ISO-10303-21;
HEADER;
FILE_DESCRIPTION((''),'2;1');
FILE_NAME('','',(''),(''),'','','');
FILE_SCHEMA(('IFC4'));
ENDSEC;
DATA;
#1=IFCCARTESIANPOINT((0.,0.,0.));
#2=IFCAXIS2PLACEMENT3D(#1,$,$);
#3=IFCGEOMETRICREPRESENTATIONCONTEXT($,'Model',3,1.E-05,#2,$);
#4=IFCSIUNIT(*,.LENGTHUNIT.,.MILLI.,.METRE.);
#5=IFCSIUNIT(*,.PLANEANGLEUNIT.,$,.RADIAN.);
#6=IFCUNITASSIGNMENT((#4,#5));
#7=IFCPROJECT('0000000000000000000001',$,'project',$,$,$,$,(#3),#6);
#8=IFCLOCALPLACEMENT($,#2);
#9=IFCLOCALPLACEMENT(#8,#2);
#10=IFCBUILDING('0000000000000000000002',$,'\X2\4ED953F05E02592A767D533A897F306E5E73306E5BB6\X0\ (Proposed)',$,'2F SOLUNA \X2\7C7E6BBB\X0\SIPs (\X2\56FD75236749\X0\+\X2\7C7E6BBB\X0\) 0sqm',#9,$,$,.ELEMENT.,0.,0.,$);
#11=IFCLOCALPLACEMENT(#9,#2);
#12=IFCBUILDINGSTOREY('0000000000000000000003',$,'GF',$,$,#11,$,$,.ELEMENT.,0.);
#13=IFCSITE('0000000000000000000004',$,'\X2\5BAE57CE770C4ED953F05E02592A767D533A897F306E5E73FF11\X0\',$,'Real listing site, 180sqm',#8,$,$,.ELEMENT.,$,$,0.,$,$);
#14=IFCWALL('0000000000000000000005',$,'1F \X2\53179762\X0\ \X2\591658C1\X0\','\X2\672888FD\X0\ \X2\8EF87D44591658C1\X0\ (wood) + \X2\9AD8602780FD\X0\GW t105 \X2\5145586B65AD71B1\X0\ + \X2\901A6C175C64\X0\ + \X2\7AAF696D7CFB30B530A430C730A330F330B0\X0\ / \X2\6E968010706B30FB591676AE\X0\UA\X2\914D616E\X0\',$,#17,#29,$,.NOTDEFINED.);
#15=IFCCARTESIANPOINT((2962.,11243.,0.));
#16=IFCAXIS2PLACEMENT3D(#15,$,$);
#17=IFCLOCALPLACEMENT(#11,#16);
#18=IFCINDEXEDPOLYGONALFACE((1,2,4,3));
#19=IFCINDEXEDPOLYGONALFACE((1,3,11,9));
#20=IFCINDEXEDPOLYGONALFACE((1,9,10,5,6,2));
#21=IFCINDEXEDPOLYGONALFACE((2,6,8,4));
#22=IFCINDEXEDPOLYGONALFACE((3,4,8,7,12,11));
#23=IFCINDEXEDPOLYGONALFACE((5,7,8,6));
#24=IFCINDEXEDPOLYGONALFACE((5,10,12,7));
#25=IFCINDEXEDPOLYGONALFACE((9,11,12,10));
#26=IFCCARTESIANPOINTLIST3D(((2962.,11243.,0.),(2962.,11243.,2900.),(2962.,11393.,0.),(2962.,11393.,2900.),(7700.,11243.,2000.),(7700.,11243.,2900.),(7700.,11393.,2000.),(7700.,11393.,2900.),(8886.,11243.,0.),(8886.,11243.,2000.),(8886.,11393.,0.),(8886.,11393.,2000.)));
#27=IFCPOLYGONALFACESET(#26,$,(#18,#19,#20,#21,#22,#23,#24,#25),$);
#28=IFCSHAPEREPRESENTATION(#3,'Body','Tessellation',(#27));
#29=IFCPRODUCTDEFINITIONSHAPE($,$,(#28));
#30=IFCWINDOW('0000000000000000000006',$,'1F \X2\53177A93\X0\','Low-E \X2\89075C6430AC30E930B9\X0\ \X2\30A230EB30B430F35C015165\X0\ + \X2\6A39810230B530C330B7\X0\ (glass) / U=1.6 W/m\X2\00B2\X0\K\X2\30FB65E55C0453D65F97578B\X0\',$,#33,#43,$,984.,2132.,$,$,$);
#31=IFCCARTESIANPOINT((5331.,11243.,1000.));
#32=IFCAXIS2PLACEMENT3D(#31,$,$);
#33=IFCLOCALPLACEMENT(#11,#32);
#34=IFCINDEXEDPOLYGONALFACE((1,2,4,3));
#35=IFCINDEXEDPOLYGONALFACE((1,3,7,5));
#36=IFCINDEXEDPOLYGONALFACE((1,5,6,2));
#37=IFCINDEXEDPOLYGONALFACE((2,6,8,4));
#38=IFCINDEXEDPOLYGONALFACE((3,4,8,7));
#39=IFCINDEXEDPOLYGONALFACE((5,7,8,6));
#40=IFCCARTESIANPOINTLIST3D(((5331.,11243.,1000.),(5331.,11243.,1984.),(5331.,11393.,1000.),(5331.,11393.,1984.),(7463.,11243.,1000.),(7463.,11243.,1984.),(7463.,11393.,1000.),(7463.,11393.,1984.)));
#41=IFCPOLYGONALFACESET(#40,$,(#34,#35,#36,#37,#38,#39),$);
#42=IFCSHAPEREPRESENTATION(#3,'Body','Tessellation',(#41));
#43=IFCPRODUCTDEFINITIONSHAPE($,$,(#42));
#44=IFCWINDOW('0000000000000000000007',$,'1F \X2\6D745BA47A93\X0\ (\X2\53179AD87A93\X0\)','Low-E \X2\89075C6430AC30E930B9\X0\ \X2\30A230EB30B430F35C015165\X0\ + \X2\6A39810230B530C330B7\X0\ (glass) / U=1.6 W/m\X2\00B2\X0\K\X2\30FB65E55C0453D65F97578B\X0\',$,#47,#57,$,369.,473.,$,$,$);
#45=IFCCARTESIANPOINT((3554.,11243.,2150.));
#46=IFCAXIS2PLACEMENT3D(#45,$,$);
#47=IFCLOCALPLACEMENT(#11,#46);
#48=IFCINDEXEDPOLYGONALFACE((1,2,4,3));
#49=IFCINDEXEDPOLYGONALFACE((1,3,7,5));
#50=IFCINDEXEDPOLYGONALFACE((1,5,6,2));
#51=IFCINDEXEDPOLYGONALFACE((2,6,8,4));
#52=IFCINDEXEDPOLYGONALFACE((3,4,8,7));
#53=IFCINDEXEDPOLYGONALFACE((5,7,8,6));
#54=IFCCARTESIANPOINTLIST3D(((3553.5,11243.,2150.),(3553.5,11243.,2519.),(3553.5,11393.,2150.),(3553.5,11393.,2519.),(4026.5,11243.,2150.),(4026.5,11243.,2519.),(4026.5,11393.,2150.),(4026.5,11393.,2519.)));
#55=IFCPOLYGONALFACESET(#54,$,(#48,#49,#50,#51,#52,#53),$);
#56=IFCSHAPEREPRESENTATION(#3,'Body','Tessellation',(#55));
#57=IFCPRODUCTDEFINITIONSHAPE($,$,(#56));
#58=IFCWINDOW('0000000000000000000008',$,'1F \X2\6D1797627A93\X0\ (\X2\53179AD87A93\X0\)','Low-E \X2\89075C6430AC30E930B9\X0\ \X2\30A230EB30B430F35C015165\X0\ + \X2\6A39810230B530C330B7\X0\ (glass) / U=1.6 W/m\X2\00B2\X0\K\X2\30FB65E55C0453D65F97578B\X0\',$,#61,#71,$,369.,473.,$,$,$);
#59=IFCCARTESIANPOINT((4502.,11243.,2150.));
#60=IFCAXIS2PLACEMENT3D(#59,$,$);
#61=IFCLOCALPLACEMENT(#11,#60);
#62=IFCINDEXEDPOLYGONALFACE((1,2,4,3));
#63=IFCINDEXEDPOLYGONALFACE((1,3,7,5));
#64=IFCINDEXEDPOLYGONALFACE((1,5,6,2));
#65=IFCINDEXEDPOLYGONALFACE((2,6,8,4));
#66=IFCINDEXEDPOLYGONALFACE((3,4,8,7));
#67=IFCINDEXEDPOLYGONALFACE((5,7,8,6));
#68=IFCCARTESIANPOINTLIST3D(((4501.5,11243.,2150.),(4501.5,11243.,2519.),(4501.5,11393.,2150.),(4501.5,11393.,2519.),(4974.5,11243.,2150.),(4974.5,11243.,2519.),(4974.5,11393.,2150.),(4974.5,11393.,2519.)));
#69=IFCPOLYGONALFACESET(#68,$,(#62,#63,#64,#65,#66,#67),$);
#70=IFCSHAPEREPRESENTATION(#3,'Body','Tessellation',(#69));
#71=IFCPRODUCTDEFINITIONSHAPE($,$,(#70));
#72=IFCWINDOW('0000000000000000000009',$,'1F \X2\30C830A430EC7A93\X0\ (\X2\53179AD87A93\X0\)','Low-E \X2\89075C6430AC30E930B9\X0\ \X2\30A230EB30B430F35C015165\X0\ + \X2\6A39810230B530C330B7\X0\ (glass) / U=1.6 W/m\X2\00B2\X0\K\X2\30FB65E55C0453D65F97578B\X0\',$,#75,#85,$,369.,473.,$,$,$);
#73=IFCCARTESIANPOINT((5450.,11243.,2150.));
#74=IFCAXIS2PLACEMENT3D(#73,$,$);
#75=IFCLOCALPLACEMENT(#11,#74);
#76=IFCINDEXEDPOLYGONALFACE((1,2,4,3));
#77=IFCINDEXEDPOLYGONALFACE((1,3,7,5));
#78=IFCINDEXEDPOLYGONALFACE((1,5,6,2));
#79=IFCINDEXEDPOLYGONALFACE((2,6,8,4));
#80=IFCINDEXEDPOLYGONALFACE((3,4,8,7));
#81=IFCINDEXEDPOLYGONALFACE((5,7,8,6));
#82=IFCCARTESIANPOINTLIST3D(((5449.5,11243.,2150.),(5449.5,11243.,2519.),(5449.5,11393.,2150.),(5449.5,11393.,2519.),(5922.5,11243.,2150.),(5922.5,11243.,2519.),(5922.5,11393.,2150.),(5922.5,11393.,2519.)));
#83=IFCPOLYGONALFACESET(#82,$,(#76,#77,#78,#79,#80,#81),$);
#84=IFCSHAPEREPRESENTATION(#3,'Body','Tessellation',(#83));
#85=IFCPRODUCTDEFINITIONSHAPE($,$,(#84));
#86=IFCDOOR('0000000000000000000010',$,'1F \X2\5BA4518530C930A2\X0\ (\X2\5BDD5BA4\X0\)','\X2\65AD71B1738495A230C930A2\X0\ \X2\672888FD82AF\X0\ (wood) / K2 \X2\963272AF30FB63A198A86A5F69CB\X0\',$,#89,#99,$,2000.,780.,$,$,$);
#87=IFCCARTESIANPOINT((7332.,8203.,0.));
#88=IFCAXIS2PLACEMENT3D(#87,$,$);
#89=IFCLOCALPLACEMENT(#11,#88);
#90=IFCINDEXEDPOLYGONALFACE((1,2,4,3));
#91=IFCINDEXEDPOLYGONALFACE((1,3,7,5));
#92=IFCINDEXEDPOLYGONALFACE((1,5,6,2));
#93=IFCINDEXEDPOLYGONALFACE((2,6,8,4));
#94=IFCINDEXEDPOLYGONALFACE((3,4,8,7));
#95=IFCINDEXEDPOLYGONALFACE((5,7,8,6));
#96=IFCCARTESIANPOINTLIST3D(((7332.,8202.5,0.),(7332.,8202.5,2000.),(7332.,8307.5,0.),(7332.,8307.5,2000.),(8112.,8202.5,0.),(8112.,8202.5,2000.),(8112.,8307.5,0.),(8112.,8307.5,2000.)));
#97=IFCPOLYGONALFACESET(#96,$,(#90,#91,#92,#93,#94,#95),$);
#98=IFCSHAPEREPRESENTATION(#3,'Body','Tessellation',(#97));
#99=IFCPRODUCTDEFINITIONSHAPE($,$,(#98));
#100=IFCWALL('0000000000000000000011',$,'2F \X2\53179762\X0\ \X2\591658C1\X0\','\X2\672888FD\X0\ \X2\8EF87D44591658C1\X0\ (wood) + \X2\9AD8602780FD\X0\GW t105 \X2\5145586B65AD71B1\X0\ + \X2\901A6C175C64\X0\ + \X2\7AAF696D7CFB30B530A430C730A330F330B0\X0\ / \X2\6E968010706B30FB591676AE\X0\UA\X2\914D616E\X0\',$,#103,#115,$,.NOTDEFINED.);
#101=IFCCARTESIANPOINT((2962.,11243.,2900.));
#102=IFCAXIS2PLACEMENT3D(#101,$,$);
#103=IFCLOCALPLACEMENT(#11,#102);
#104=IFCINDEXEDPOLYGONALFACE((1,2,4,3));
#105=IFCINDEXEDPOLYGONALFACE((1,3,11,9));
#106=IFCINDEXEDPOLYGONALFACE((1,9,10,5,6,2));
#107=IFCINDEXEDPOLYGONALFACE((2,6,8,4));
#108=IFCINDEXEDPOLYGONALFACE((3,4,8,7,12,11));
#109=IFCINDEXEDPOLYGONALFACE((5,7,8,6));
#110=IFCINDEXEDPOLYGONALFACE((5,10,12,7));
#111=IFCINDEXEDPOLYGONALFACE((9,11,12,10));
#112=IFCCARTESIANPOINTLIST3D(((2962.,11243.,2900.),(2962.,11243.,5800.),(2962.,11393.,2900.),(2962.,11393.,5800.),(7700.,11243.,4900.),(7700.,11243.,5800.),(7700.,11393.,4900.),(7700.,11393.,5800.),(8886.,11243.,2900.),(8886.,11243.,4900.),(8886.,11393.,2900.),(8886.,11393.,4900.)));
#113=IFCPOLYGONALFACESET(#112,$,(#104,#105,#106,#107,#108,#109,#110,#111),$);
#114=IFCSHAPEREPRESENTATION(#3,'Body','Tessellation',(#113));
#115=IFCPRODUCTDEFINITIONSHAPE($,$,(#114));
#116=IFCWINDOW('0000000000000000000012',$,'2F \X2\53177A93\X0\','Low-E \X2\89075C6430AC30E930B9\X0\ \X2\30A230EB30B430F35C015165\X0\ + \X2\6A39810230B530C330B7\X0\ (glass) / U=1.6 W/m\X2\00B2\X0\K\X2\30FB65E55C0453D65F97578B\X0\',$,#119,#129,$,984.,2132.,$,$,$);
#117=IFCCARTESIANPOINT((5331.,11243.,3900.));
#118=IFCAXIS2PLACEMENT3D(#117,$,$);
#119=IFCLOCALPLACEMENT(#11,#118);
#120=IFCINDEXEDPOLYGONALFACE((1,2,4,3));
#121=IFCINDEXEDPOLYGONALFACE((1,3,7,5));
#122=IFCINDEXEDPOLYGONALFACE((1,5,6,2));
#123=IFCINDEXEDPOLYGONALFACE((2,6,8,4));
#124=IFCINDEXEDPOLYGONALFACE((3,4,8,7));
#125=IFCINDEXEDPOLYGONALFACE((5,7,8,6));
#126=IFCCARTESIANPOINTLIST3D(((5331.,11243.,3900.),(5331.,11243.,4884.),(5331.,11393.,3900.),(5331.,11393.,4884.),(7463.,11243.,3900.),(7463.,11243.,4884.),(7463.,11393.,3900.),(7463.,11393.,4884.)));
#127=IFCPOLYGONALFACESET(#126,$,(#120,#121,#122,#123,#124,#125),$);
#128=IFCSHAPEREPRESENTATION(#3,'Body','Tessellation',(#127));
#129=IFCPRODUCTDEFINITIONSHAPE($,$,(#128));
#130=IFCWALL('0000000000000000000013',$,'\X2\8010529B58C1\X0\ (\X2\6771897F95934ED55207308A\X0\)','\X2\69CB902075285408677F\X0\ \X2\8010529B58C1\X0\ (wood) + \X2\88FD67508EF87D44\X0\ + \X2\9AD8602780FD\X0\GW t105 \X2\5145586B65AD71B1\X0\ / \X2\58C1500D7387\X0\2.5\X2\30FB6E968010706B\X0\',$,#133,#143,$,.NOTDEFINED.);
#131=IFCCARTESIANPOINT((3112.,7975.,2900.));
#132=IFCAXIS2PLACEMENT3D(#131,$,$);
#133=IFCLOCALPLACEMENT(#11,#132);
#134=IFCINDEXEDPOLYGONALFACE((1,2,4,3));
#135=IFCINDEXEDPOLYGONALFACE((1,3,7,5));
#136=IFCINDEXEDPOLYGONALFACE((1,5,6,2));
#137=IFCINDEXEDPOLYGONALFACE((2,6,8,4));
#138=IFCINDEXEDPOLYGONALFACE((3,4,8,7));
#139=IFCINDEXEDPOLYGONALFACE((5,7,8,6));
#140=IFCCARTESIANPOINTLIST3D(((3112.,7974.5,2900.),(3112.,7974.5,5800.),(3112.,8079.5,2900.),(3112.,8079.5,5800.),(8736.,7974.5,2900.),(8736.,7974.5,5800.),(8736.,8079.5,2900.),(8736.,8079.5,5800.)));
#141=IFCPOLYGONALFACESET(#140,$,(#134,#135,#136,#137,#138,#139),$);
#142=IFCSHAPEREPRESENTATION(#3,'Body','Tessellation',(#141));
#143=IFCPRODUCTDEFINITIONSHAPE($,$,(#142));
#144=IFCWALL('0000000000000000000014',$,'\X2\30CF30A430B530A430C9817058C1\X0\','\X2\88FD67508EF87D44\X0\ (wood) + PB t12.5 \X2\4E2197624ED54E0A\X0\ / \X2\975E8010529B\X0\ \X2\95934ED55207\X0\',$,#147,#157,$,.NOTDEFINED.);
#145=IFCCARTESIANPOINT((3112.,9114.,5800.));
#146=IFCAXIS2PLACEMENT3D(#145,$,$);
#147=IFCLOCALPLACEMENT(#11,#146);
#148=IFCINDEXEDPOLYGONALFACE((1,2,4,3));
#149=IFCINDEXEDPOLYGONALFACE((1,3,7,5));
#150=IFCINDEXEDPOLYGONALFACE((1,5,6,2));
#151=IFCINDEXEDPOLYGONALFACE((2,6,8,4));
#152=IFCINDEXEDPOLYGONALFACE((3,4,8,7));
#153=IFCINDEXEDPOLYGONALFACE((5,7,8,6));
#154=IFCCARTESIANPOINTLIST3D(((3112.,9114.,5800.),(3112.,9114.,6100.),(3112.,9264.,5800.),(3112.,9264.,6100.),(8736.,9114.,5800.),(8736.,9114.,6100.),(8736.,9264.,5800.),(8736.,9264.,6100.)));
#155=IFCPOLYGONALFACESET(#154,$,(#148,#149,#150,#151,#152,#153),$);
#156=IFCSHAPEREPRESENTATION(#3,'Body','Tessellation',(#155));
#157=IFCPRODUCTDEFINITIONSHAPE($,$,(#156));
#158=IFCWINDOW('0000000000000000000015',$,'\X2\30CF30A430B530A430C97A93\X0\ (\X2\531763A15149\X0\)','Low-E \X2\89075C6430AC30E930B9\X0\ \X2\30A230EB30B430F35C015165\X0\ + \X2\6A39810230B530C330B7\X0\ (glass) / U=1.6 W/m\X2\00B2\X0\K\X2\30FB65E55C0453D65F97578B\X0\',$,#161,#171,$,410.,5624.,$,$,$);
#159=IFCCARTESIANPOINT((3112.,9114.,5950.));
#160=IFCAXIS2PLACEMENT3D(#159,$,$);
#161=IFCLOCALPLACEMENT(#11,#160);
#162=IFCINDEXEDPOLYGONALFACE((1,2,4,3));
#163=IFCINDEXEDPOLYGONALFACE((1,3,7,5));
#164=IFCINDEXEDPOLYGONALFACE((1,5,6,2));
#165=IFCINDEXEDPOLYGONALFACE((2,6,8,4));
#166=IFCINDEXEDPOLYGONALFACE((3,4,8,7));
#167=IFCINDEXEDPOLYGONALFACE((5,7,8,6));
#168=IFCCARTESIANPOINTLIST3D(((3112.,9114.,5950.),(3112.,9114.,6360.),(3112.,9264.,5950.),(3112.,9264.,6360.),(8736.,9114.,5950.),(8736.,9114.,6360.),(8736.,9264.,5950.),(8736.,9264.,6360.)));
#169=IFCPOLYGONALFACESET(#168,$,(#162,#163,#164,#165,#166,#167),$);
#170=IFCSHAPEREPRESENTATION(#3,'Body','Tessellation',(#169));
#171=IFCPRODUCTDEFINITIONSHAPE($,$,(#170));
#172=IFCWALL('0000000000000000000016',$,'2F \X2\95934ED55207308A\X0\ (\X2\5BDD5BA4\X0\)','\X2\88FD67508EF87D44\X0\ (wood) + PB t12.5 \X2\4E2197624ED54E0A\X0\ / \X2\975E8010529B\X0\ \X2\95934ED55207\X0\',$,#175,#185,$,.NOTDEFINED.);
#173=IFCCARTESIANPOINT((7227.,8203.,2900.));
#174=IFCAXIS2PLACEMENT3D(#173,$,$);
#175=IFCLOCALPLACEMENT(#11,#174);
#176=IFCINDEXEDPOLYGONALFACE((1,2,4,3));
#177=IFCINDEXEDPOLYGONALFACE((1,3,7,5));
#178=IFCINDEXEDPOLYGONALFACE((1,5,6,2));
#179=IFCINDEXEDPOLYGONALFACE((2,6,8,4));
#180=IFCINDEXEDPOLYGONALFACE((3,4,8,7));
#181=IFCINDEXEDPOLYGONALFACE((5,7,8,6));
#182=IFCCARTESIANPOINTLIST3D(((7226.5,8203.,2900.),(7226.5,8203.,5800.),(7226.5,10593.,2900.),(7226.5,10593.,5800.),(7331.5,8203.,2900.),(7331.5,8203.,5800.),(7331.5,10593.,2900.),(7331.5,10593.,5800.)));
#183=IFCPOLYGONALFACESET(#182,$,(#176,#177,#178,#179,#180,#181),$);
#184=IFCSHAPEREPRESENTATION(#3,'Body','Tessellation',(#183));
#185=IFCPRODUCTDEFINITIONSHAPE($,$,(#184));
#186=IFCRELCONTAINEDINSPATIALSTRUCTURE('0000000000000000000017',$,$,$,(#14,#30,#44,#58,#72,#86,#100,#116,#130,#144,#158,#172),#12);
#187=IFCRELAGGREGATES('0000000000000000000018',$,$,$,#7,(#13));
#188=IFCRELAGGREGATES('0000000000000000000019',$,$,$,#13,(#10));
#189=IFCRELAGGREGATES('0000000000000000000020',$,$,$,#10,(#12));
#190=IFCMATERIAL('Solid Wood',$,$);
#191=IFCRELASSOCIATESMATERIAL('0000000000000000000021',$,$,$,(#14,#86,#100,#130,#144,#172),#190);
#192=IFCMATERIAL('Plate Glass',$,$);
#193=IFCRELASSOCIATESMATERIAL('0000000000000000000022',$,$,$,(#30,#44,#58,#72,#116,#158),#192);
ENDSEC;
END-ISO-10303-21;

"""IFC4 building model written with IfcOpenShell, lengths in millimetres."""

from ifc_helpers import new_model, si_unit, frame, frame_2d, origin, place, context, project, spatial, rectangle, extrude, material, element, fill, save


model = new_model("IFC4")

# Units and contexts
model_context = context("Model", 3, precision=1e-05, world=origin())
ifc_project = project(units=[si_unit("LENGTHUNIT", "METRE", prefix="MILLI"), si_unit("PLANEANGLEUNIT", "RADIAN")], contexts=[model_context])

# Site, building, storey
site_placement = place(None, origin())
site = spatial("IfcSite", under=ifc_project, at=site_placement, Name="宮城県仙台市太白区西の平１", ObjectType="Real listing site, 180sqm", CompositionType="ELEMENT", RefElevation=0.0)
building_placement = place(site_placement, origin())
building = spatial("IfcBuilding", under=site, at=building_placement, Name="仙台市太白区西の平の家 (Proposed)", ObjectType="2F SOLUNA 籾殻SIPs (国産杉+籾殻) 0sqm", CompositionType="ELEMENT", ElevationOfRefHeight=0.0, ElevationOfTerrain=0.0)
storey_placement = place(building_placement, origin())
storey = spatial("IfcBuildingStorey", under=building, at=storey_placement, Name="GF", CompositionType="ELEMENT", Elevation=0.0)

# Wall, openings, windows
ifc_material_1 = material(Name="Solid Wood")
wall_1_placement = place(storey_placement, frame((2962.0, 11243.0, 0.0)))
wall_1 = element("IfcWall", 1, at=wall_1_placement, inside=storey, material=ifc_material_1, Name="1F 北面 外壁", Description="木製 軸組外壁 (wood) + 高性能GW t105 充填断熱 + 通気層 + 窯業系サイディング / 準耐火・外皮UA配慮", PredefinedType="NOTDEFINED", context=model_context, shape_type="SweptSolid", body=[
    extrude(rectangle(XDim=5924.0, YDim=150.0, at=frame_2d((2962.0, 75.0))), frame((2962.0, 11243.0, 0.0)), (0.0, 0.0, 1.0), 2900.0),
])
opening_1_placement = place(storey_placement, frame((5331.0, 11243.0, 1000.0)))
opening_1 = element("IfcOpeningElement", 2, at=opening_1_placement, cuts=wall_1, PredefinedType="NOTDEFINED", context=model_context, shape_type="SweptSolid", body=[
    extrude(rectangle(XDim=2132.0, YDim=150.0, at=frame_2d((1066.0, 75.0))), frame((5331.0, 11243.0, 1000.0)), (0.0, 0.0, 1.0), 984.0),
])
opening_2_placement = place(storey_placement, frame((3554.0, 11243.0, 2150.0)))
opening_2 = element("IfcOpeningElement", 3, at=opening_2_placement, cuts=wall_1, PredefinedType="NOTDEFINED", context=model_context, shape_type="SweptSolid", body=[
    extrude(rectangle(XDim=473.0, YDim=150.0, at=frame_2d((236.0, 75.0))), frame((3554.0, 11243.0, 2150.0)), (0.0, 0.0, 1.0), 369.0),
])
opening_3_placement = place(storey_placement, frame((4502.0, 11243.0, 2150.0)))
opening_3 = element("IfcOpeningElement", 4, at=opening_3_placement, cuts=wall_1, PredefinedType="NOTDEFINED", context=model_context, shape_type="SweptSolid", body=[
    extrude(rectangle(XDim=473.0, YDim=150.0, at=frame_2d((236.0, 75.0))), frame((4502.0, 11243.0, 2150.0)), (0.0, 0.0, 1.0), 369.0),
])
opening_4_placement = place(storey_placement, frame((5450.0, 11243.0, 2150.0)))
opening_4 = element("IfcOpeningElement", 5, at=opening_4_placement, cuts=wall_1, PredefinedType="NOTDEFINED", context=model_context, shape_type="SweptSolid", body=[
    extrude(rectangle(XDim=473.0, YDim=150.0, at=frame_2d((236.0, 75.0))), frame((5450.0, 11243.0, 2150.0)), (0.0, 0.0, 1.0), 369.0),
])
ifc_material_2 = material(Name="Plate Glass")
window_1_placement = place(storey_placement, frame((5331.0, 11243.0, 1000.0)))
window_1 = element("IfcWindow", 6, at=window_1_placement, inside=storey, material=ifc_material_2, Name="1F 北窓", Description="Low-E 複層ガラス アルゴン封入 + 樹脂サッシ (glass) / U=1.6 W/m²K・日射取得型", OverallHeight=984.0, OverallWidth=2132.0, context=model_context, shape_type="SweptSolid", body=[
    extrude(rectangle(XDim=2132.0, YDim=150.0, at=frame_2d((1066.0, 75.0))), frame((5331.0, 11243.0, 1000.0)), (0.0, 0.0, 1.0), 984.0),
])
fill(opening_1, window_1)
window_2_placement = place(storey_placement, frame((3554.0, 11243.0, 2150.0)))
window_2 = element("IfcWindow", 7, at=window_2_placement, inside=storey, material=ifc_material_2, Name="1F 浴室窓 (北高窓)", Description="Low-E 複層ガラス アルゴン封入 + 樹脂サッシ (glass) / U=1.6 W/m²K・日射取得型", OverallHeight=369.0, OverallWidth=473.0, context=model_context, shape_type="SweptSolid", body=[
    extrude(rectangle(XDim=473.0, YDim=150.0, at=frame_2d((236.0, 75.0))), frame((3554.0, 11243.0, 2150.0)), (0.0, 0.0, 1.0), 369.0),
])
fill(opening_2, window_2)
window_3_placement = place(storey_placement, frame((4502.0, 11243.0, 2150.0)))
window_3 = element("IfcWindow", 8, at=window_3_placement, inside=storey, material=ifc_material_2, Name="1F 洗面窓 (北高窓)", Description="Low-E 複層ガラス アルゴン封入 + 樹脂サッシ (glass) / U=1.6 W/m²K・日射取得型", OverallHeight=369.0, OverallWidth=473.0, context=model_context, shape_type="SweptSolid", body=[
    extrude(rectangle(XDim=473.0, YDim=150.0, at=frame_2d((236.0, 75.0))), frame((4502.0, 11243.0, 2150.0)), (0.0, 0.0, 1.0), 369.0),
])
fill(opening_3, window_3)
window_4_placement = place(storey_placement, frame((5450.0, 11243.0, 2150.0)))
window_4 = element("IfcWindow", 9, at=window_4_placement, inside=storey, material=ifc_material_2, Name="1F トイレ窓 (北高窓)", Description="Low-E 複層ガラス アルゴン封入 + 樹脂サッシ (glass) / U=1.6 W/m²K・日射取得型", OverallHeight=369.0, OverallWidth=473.0, context=model_context, shape_type="SweptSolid", body=[
    extrude(rectangle(XDim=473.0, YDim=150.0, at=frame_2d((236.0, 75.0))), frame((5450.0, 11243.0, 2150.0)), (0.0, 0.0, 1.0), 369.0),
])
fill(opening_4, window_4)

# Door
door_1_placement = place(storey_placement, frame((7332.0, 8203.0, 0.0)))
element("IfcDoor", 10, at=door_1_placement, inside=storey, material=ifc_material_1, Name="1F 室内ドア (寝室)", Description="断熱玄関ドア 木製芯 (wood) / K2 防犯・採風機構", OverallHeight=2000.0, OverallWidth=780.0, context=model_context, shape_type="SweptSolid", body=[
    extrude(rectangle(XDim=780.0, YDim=105.0, at=frame_2d((390.0, 52.0))), frame((7332.0, 8203.0, 0.0)), (0.0, 0.0, 1.0), 2000.0),
])

# Wall, opening, window
wall_2_placement = place(storey_placement, frame((2962.0, 11243.0, 2900.0)))
wall_2 = element("IfcWall", 11, at=wall_2_placement, inside=storey, material=ifc_material_1, Name="2F 北面 外壁", Description="木製 軸組外壁 (wood) + 高性能GW t105 充填断熱 + 通気層 + 窯業系サイディング / 準耐火・外皮UA配慮", PredefinedType="NOTDEFINED", context=model_context, shape_type="SweptSolid", body=[
    extrude(rectangle(XDim=5924.0, YDim=150.0, at=frame_2d((2962.0, 75.0))), frame((2962.0, 11243.0, 2900.0)), (0.0, 0.0, 1.0), 2900.0),
])
opening_5_placement = place(storey_placement, frame((5331.0, 11243.0, 3900.0)))
opening_5 = element("IfcOpeningElement", 12, at=opening_5_placement, cuts=wall_2, PredefinedType="NOTDEFINED", context=model_context, shape_type="SweptSolid", body=[
    extrude(rectangle(XDim=2132.0, YDim=150.0, at=frame_2d((1066.0, 75.0))), frame((5331.0, 11243.0, 3900.0)), (0.0, 0.0, 1.0), 984.0),
])
window_5_placement = place(storey_placement, frame((5331.0, 11243.0, 3900.0)))
window_5 = element("IfcWindow", 13, at=window_5_placement, inside=storey, material=ifc_material_2, Name="2F 北窓", Description="Low-E 複層ガラス アルゴン封入 + 樹脂サッシ (glass) / U=1.6 W/m²K・日射取得型", OverallHeight=984.0, OverallWidth=2132.0, context=model_context, shape_type="SweptSolid", body=[
    extrude(rectangle(XDim=2132.0, YDim=150.0, at=frame_2d((1066.0, 75.0))), frame((5331.0, 11243.0, 3900.0)), (0.0, 0.0, 1.0), 984.0),
])
fill(opening_5, window_5)

# Wall
wall_3_placement = place(storey_placement, frame((3112.0, 7975.0, 2900.0)))
element("IfcWall", 14, at=wall_3_placement, inside=storey, material=ifc_material_1, Name="耐力壁 (東西間仕切り)", Description="構造用合板 耐力壁 (wood) + 製材軸組 + 高性能GW t105 充填断熱 / 壁倍率2.5・準耐火", PredefinedType="NOTDEFINED", context=model_context, shape_type="SweptSolid", body=[
    extrude(rectangle(XDim=5624.0, YDim=105.0, at=frame_2d((2812.0, 52.0))), frame((3112.0, 7975.0, 2900.0)), (0.0, 0.0, 1.0), 2900.0),
])

# Wall, opening, window
wall_4_placement = place(storey_placement, frame((3112.0, 9114.0, 5800.0)))
wall_4 = element("IfcWall", 15, at=wall_4_placement, inside=storey, material=ifc_material_1, Name="ハイサイド腰壁", Description="製材軸組 (wood) + PB t12.5 両面仕上 / 非耐力 間仕切", PredefinedType="NOTDEFINED", context=model_context, shape_type="SweptSolid", body=[
    extrude(rectangle(XDim=5624.0, YDim=150.0, at=frame_2d((2812.0, 75.0))), frame((3112.0, 9114.0, 5800.0)), (0.0, 0.0, 1.0), 700.0),
])
opening_6_placement = place(storey_placement, frame((3112.0, 9114.0, 5950.0)))
opening_6 = element("IfcOpeningElement", 16, at=opening_6_placement, cuts=wall_4, PredefinedType="NOTDEFINED", context=model_context, shape_type="SweptSolid", body=[
    extrude(rectangle(XDim=5624.0, YDim=150.0, at=frame_2d((2812.0, 75.0))), frame((3112.0, 9114.0, 5950.0)), (0.0, 0.0, 1.0), 410.0),
])
window_6_placement = place(storey_placement, frame((3112.0, 9114.0, 5950.0)))
window_6 = element("IfcWindow", 17, at=window_6_placement, inside=storey, material=ifc_material_2, Name="ハイサイド窓 (北採光)", Description="Low-E 複層ガラス アルゴン封入 + 樹脂サッシ (glass) / U=1.6 W/m²K・日射取得型", OverallHeight=410.0, OverallWidth=5624.0, context=model_context, shape_type="SweptSolid", body=[
    extrude(rectangle(XDim=5624.0, YDim=150.0, at=frame_2d((2812.0, 75.0))), frame((3112.0, 9114.0, 5950.0)), (0.0, 0.0, 1.0), 410.0),
])
fill(opening_6, window_6)

# Wall
wall_5_placement = place(storey_placement, frame((7227.0, 8203.0, 2900.0)))
element("IfcWall", 18, at=wall_5_placement, inside=storey, material=ifc_material_1, Name="2F 間仕切り (寝室)", Description="製材軸組 (wood) + PB t12.5 両面仕上 / 非耐力 間仕切", PredefinedType="NOTDEFINED", context=model_context, shape_type="SweptSolid", body=[
    extrude(rectangle(XDim=105.0, YDim=2390.0, at=frame_2d((52.0, 1195.0))), frame((7227.0, 8203.0, 2900.0)), (0.0, 0.0, 1.0), 2900.0),
])

save(model, "model.ifc")
